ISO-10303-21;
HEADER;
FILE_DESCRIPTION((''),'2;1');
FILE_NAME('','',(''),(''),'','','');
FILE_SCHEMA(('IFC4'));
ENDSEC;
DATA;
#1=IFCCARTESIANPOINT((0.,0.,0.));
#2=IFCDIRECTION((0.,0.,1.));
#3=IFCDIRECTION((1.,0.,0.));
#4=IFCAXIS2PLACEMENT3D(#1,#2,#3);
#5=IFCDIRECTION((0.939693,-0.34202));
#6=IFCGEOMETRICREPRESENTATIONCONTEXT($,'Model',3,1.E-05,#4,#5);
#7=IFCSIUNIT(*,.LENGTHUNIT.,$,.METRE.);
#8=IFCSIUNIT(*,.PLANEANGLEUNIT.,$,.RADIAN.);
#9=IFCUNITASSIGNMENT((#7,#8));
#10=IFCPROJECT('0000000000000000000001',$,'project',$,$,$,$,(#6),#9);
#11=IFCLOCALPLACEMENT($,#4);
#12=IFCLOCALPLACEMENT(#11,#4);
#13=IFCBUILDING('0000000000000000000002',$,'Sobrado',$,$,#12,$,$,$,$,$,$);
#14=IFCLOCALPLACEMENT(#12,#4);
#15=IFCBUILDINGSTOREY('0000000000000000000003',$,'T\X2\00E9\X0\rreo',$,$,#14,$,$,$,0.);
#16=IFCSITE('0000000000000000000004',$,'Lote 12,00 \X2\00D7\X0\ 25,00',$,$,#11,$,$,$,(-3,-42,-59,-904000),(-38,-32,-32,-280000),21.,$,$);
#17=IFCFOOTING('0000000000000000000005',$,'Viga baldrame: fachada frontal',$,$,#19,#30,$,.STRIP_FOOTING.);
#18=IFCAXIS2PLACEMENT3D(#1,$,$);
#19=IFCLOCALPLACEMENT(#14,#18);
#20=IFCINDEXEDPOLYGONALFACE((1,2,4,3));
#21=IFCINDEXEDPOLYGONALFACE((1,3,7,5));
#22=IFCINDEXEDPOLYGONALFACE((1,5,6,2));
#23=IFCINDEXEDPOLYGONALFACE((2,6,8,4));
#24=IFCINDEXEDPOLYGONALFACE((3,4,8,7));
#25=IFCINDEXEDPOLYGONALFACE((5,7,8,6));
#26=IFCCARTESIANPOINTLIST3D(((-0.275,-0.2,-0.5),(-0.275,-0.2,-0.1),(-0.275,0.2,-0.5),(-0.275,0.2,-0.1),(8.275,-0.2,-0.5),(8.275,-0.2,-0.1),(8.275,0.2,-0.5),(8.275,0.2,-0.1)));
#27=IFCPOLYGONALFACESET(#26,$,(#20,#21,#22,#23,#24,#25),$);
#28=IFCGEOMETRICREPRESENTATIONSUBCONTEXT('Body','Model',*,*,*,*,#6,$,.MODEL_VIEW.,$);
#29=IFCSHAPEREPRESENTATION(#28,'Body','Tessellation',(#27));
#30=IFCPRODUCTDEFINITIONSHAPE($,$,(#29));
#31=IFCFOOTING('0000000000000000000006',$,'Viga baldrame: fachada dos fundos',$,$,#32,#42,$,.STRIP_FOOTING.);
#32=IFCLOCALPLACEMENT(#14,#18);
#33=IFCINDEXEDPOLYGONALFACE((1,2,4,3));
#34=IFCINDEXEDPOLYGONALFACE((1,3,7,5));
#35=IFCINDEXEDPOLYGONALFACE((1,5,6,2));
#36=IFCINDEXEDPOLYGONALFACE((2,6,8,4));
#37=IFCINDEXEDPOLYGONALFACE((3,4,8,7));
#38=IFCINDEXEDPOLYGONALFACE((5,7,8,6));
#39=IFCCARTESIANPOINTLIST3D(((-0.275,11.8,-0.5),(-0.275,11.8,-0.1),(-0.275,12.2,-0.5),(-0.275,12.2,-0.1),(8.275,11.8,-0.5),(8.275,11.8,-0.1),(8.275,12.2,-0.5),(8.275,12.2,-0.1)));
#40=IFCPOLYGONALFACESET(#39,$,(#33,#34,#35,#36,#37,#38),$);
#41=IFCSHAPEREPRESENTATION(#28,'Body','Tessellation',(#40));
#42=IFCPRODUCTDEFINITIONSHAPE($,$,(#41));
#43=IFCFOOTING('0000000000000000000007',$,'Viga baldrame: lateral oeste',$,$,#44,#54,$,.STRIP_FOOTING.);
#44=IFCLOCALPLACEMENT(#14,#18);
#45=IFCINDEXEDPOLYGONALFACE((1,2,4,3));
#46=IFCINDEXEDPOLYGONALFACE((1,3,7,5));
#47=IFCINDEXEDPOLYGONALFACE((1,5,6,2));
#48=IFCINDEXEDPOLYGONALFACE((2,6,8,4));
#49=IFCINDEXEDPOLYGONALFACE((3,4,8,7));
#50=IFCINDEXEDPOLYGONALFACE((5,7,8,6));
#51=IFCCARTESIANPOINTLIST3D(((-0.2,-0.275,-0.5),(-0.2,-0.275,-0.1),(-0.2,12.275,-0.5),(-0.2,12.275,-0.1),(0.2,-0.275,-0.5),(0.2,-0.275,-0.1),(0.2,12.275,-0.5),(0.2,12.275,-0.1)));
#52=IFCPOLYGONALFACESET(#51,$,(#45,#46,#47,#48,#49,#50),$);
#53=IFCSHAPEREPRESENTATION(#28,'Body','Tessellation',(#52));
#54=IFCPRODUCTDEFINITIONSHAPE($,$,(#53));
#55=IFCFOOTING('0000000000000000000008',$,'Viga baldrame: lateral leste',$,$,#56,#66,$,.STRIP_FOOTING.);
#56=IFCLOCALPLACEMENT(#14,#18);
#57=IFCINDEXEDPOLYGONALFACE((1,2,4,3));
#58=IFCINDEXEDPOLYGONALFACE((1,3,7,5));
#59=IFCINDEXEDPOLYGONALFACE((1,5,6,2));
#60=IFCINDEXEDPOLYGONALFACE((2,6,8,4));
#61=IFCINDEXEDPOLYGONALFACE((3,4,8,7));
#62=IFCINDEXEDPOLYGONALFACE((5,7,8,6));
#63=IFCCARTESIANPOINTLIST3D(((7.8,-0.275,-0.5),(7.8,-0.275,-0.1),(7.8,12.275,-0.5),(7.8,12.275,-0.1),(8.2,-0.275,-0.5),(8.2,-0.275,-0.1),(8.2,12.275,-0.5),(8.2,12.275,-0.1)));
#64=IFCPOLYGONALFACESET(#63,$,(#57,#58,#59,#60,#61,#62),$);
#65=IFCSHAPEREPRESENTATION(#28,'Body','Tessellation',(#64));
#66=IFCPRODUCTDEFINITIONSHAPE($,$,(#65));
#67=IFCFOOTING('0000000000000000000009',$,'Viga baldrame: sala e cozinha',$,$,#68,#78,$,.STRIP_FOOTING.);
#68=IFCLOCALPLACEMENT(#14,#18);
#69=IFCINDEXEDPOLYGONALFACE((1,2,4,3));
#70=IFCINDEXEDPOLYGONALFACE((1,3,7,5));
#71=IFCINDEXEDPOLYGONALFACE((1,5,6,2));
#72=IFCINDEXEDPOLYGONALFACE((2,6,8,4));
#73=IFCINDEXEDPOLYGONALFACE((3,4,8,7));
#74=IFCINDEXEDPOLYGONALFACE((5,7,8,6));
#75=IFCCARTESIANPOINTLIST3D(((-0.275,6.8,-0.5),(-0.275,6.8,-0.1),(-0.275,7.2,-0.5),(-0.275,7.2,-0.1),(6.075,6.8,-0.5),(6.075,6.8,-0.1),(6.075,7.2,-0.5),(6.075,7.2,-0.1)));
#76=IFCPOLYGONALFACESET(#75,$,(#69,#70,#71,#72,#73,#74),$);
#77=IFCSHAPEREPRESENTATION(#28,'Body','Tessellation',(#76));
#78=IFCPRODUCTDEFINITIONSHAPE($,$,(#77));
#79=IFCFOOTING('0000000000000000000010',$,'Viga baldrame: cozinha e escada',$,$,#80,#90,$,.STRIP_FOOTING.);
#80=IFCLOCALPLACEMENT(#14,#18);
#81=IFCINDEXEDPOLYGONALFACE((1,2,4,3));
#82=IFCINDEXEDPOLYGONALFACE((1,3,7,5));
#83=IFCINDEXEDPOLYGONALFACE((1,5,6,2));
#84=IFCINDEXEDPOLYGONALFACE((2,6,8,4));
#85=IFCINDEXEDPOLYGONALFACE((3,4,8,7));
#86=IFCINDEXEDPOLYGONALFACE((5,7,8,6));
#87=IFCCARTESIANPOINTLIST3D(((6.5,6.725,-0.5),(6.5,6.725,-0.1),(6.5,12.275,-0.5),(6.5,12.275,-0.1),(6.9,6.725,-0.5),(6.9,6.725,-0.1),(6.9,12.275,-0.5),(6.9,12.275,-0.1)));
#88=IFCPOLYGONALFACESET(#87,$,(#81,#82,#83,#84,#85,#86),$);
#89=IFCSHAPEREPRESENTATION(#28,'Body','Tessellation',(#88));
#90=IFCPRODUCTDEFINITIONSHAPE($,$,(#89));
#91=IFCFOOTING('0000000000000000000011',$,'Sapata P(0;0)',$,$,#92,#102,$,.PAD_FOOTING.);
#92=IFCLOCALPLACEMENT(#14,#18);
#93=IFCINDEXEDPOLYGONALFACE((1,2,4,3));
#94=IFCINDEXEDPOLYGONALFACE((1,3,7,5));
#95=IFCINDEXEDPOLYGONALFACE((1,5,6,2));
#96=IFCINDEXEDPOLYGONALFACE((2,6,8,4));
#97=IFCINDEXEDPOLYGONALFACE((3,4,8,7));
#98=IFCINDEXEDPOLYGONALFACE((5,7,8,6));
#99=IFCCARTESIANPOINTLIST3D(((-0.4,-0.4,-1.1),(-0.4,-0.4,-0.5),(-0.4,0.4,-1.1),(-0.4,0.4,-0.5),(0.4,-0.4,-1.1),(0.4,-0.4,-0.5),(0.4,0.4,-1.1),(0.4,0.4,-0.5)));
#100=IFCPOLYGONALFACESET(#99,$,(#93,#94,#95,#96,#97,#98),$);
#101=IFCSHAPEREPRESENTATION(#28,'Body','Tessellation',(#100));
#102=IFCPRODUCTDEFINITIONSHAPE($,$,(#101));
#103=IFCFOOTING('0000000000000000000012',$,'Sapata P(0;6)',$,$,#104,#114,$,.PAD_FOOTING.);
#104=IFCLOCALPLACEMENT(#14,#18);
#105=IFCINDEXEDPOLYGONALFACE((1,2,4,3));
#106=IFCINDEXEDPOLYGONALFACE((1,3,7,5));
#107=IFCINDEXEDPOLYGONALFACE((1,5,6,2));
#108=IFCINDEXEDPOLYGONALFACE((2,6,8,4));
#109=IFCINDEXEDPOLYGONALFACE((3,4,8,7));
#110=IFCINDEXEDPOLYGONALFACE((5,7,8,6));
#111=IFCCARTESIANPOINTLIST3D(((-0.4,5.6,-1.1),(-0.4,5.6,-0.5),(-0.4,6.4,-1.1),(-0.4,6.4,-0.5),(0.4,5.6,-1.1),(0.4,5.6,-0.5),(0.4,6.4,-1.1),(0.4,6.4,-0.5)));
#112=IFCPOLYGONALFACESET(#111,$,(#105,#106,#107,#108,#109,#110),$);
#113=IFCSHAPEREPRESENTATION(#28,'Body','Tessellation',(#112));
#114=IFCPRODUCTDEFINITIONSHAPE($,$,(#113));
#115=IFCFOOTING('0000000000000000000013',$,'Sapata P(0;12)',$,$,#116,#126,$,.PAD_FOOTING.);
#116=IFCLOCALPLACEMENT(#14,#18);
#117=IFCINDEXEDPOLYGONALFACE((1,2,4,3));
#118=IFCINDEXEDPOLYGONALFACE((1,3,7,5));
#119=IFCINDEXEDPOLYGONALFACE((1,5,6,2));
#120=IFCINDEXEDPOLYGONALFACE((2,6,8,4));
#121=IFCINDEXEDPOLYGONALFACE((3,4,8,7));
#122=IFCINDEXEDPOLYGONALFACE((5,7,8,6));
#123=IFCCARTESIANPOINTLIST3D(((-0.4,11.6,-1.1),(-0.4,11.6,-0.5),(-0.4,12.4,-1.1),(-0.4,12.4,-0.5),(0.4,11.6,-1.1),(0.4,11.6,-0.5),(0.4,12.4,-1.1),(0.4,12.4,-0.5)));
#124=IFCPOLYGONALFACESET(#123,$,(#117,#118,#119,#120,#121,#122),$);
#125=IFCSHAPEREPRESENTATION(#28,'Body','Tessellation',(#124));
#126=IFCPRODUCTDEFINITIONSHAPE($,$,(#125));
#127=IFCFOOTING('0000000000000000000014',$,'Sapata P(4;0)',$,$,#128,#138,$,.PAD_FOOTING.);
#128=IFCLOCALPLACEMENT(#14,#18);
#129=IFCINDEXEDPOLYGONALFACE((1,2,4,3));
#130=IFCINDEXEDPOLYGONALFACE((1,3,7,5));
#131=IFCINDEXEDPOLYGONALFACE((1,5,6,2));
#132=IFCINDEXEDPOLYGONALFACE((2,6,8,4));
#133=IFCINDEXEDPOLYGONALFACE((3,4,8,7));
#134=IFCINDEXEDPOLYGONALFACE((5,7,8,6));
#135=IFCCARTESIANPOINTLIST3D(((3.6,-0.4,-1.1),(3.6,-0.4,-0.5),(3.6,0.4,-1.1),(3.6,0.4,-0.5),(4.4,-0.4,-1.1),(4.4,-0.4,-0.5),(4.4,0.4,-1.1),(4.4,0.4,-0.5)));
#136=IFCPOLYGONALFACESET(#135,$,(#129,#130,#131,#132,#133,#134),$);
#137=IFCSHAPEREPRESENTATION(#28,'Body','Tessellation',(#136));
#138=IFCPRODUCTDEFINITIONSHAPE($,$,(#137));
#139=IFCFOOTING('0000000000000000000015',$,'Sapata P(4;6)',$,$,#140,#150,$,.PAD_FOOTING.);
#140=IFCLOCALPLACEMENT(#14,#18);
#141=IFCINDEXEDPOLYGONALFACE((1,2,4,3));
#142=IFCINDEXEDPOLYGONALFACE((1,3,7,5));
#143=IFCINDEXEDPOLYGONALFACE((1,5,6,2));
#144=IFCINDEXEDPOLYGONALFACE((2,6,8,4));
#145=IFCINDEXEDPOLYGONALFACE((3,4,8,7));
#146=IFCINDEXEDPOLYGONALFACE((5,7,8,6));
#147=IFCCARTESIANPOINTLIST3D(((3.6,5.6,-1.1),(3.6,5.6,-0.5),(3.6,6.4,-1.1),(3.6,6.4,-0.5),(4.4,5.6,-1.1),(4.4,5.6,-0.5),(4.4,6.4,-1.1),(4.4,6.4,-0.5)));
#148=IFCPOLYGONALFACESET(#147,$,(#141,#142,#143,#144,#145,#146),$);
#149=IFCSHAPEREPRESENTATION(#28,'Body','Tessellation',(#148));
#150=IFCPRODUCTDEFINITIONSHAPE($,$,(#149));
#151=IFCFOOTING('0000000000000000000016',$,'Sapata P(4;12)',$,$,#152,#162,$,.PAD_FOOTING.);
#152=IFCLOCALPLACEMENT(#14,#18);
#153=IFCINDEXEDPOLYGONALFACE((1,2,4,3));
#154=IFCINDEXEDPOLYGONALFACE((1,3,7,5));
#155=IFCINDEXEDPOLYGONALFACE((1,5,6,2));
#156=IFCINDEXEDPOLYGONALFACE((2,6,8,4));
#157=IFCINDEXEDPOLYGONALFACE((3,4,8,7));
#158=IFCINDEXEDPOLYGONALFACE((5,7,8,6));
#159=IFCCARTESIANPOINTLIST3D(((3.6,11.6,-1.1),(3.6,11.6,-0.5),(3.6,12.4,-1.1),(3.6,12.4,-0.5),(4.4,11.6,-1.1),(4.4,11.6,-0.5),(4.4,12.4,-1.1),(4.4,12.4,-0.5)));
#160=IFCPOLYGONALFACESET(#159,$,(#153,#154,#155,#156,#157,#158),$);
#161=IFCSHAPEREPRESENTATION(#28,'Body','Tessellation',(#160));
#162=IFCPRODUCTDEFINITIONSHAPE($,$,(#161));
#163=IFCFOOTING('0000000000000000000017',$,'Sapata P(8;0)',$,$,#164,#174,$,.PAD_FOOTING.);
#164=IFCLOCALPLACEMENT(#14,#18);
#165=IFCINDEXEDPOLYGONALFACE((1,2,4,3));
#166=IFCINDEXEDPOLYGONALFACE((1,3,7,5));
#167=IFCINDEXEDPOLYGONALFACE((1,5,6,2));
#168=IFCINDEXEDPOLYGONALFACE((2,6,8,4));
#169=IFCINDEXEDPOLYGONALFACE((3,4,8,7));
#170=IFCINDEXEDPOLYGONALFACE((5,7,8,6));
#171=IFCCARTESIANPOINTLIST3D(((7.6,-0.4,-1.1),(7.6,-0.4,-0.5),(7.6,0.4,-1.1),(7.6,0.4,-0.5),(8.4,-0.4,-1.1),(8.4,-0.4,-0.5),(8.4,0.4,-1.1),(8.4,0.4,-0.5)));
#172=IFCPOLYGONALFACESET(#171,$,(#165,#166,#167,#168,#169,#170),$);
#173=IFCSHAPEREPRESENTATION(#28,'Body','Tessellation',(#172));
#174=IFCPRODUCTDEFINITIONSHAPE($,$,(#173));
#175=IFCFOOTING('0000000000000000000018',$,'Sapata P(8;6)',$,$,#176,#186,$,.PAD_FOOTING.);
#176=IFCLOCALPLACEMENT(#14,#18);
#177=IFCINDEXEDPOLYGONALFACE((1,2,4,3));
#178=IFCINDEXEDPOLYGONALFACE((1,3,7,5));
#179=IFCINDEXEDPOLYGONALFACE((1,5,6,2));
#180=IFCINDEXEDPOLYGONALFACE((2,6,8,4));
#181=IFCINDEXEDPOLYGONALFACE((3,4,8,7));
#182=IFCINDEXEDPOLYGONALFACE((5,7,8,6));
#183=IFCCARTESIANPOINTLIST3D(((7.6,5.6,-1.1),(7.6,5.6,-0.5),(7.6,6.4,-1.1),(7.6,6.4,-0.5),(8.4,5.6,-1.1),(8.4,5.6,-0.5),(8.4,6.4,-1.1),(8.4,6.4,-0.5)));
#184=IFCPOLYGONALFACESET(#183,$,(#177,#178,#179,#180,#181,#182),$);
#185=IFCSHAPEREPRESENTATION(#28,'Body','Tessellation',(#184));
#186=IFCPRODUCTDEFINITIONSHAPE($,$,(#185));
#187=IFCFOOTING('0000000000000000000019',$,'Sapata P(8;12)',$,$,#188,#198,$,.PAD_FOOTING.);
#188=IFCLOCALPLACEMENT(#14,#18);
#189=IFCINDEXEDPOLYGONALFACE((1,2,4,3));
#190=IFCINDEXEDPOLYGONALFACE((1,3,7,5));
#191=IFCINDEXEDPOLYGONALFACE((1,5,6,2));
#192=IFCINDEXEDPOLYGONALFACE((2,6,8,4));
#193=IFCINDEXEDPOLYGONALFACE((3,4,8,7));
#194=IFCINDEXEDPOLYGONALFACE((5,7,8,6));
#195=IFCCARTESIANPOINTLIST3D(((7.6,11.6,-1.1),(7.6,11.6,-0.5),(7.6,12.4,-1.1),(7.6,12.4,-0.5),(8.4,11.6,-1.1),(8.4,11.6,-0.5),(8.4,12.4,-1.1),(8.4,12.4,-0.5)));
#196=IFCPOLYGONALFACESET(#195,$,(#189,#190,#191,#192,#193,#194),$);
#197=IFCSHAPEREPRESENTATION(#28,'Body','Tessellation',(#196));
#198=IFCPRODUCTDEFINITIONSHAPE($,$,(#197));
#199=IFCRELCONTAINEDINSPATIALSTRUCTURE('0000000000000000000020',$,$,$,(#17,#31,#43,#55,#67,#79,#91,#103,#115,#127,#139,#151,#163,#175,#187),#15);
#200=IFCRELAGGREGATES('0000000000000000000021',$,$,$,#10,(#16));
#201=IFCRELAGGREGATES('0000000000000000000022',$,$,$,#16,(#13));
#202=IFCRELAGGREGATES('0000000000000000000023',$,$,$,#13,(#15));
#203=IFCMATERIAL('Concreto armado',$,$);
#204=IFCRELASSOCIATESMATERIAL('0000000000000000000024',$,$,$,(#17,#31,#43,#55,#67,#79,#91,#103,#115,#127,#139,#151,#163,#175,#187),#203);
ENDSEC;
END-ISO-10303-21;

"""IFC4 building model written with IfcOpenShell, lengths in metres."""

from ifc_helpers import new_model, si_unit, direction, frame, origin_with_axes, place, context, subcontext, project, spatial, line, indexed_curve, outline, extrude, material, element, save


model = new_model("IFC4")

# Units and contexts
model_context = context("Model", 3, precision=1e-05, world=origin_with_axes(), true_north=direction((0.939693, -0.34202)))
body_context = subcontext(model_context, "Body", "Model", "MODEL_VIEW")
ifc_project = project(units=[si_unit("LENGTHUNIT", "METRE"), si_unit("PLANEANGLEUNIT", "RADIAN")], contexts=[model_context])

# Site, building, storey
site_placement = place(None, origin_with_axes())
site = spatial("IfcSite", under=ifc_project, at=site_placement, Name="Lote 12,00 × 25,00", RefLatitude=(-3, -42, -59, -904000), RefLongitude=(-38, -32, -32, -280000), RefElevation=21.0)
building_placement = place(site_placement, origin_with_axes())
building = spatial("IfcBuilding", under=site, at=building_placement, Name="Sobrado")
storey_placement = place(building_placement, origin_with_axes())
storey = spatial("IfcBuildingStorey", under=building, at=storey_placement, Name="Térreo", Elevation=0.0)

# Footings
ifc_material = material(Name="Concreto armado")
footing_1_placement = place(storey_placement, origin_with_axes())
element("IfcFooting", 1, at=footing_1_placement, inside=storey, material=ifc_material, Name="Viga baldrame: fachada frontal", PredefinedType="STRIP_FOOTING", context=body_context, shape_type="SweptSolid", body=[
    extrude(outline(indexed_curve([(-0.275, -0.2), (8.275, -0.2), (8.275, 0.2), (-0.275, 0.2)], segments=[line(1, 2, 3, 4, 1)])), frame((0.0, 0.0, -0.5), z_axis=(0.0, 0.0, 1.0), x_axis=(1.0, 0.0, 0.0)), (0.0, 0.0, 1.0), 0.4),
])
footing_2_placement = place(storey_placement, origin_with_axes())
element("IfcFooting", 2, at=footing_2_placement, inside=storey, material=ifc_material, Name="Viga baldrame: fachada dos fundos", PredefinedType="STRIP_FOOTING", context=body_context, shape_type="SweptSolid", body=[
    extrude(outline(indexed_curve([(-0.275, 11.8), (8.275, 11.8), (8.275, 12.2), (-0.275, 12.2)], segments=[line(1, 2, 3, 4, 1)])), frame((0.0, 0.0, -0.5), z_axis=(0.0, 0.0, 1.0), x_axis=(1.0, 0.0, 0.0)), (0.0, 0.0, 1.0), 0.4),
])
footing_3_placement = place(storey_placement, origin_with_axes())
element("IfcFooting", 3, at=footing_3_placement, inside=storey, material=ifc_material, Name="Viga baldrame: lateral oeste", PredefinedType="STRIP_FOOTING", context=body_context, shape_type="SweptSolid", body=[
    extrude(outline(indexed_curve([(-0.2, -0.275), (0.2, -0.275), (0.2, 12.275), (-0.2, 12.275)], segments=[line(1, 2, 3, 4, 1)])), frame((0.0, 0.0, -0.5), z_axis=(0.0, 0.0, 1.0), x_axis=(1.0, 0.0, 0.0)), (0.0, 0.0, 1.0), 0.4),
])
footing_4_placement = place(storey_placement, origin_with_axes())
element("IfcFooting", 4, at=footing_4_placement, inside=storey, material=ifc_material, Name="Viga baldrame: lateral leste", PredefinedType="STRIP_FOOTING", context=body_context, shape_type="SweptSolid", body=[
    extrude(outline(indexed_curve([(7.8, -0.275), (8.2, -0.275), (8.2, 12.275), (7.8, 12.275)], segments=[line(1, 2, 3, 4, 1)])), frame((0.0, 0.0, -0.5), z_axis=(0.0, 0.0, 1.0), x_axis=(1.0, 0.0, 0.0)), (0.0, 0.0, 1.0), 0.4),
])
footing_5_placement = place(storey_placement, origin_with_axes())
element("IfcFooting", 5, at=footing_5_placement, inside=storey, material=ifc_material, Name="Viga baldrame: sala e cozinha", PredefinedType="STRIP_FOOTING", context=body_context, shape_type="SweptSolid", body=[
    extrude(outline(indexed_curve([(-0.275, 6.8), (6.075, 6.8), (6.075, 7.2), (-0.275, 7.2)], segments=[line(1, 2, 3, 4, 1)])), frame((0.0, 0.0, -0.5), z_axis=(0.0, 0.0, 1.0), x_axis=(1.0, 0.0, 0.0)), (0.0, 0.0, 1.0), 0.4),
])
footing_6_placement = place(storey_placement, origin_with_axes())
element("IfcFooting", 6, at=footing_6_placement, inside=storey, material=ifc_material, Name="Viga baldrame: cozinha e escada", PredefinedType="STRIP_FOOTING", context=body_context, shape_type="SweptSolid", body=[
    extrude(outline(indexed_curve([(6.5, 6.725), (6.9, 6.725), (6.9, 12.275), (6.5, 12.275)], segments=[line(1, 2, 3, 4, 1)])), frame((0.0, 0.0, -0.5), z_axis=(0.0, 0.0, 1.0), x_axis=(1.0, 0.0, 0.0)), (0.0, 0.0, 1.0), 0.4),
])
footing_7_placement = place(storey_placement, origin_with_axes())
element("IfcFooting", 7, at=footing_7_placement, inside=storey, material=ifc_material, Name="Sapata P(0;0)", PredefinedType="PAD_FOOTING", context=body_context, shape_type="SweptSolid", body=[
    extrude(outline(indexed_curve([(-0.4, -0.4), (0.4, -0.4), (0.4, 0.4), (-0.4, 0.4)], segments=[line(1, 2, 3, 4, 1)])), frame((0.0, 0.0, -1.1), z_axis=(0.0, 0.0, 1.0), x_axis=(1.0, 0.0, 0.0)), (0.0, 0.0, 1.0), 0.6),
])
footing_8_placement = place(storey_placement, origin_with_axes())
element("IfcFooting", 8, at=footing_8_placement, inside=storey, material=ifc_material, Name="Sapata P(0;6)", PredefinedType="PAD_FOOTING", context=body_context, shape_type="SweptSolid", body=[
    extrude(outline(indexed_curve([(-0.4, 5.6), (0.4, 5.6), (0.4, 6.4), (-0.4, 6.4)], segments=[line(1, 2, 3, 4, 1)])), frame((0.0, 0.0, -1.1), z_axis=(0.0, 0.0, 1.0), x_axis=(1.0, 0.0, 0.0)), (0.0, 0.0, 1.0), 0.6),
])
footing_9_placement = place(storey_placement, origin_with_axes())
element("IfcFooting", 9, at=footing_9_placement, inside=storey, material=ifc_material, Name="Sapata P(0;12)", PredefinedType="PAD_FOOTING", context=body_context, shape_type="SweptSolid", body=[
    extrude(outline(indexed_curve([(-0.4, 11.6), (0.4, 11.6), (0.4, 12.4), (-0.4, 12.4)], segments=[line(1, 2, 3, 4, 1)])), frame((0.0, 0.0, -1.1), z_axis=(0.0, 0.0, 1.0), x_axis=(1.0, 0.0, 0.0)), (0.0, 0.0, 1.0), 0.6),
])
footing_10_placement = place(storey_placement, origin_with_axes())
element("IfcFooting", 10, at=footing_10_placement, inside=storey, material=ifc_material, Name="Sapata P(4;0)", PredefinedType="PAD_FOOTING", context=body_context, shape_type="SweptSolid", body=[
    extrude(outline(indexed_curve([(3.6, -0.4), (4.4, -0.4), (4.4, 0.4), (3.6, 0.4)], segments=[line(1, 2, 3, 4, 1)])), frame((0.0, 0.0, -1.1), z_axis=(0.0, 0.0, 1.0), x_axis=(1.0, 0.0, 0.0)), (0.0, 0.0, 1.0), 0.6),
])
footing_11_placement = place(storey_placement, origin_with_axes())
element("IfcFooting", 11, at=footing_11_placement, inside=storey, material=ifc_material, Name="Sapata P(4;6)", PredefinedType="PAD_FOOTING", context=body_context, shape_type="SweptSolid", body=[
    extrude(outline(indexed_curve([(3.6, 5.6), (4.4, 5.6), (4.4, 6.4), (3.6, 6.4)], segments=[line(1, 2, 3, 4, 1)])), frame((0.0, 0.0, -1.1), z_axis=(0.0, 0.0, 1.0), x_axis=(1.0, 0.0, 0.0)), (0.0, 0.0, 1.0), 0.6),
])
footing_12_placement = place(storey_placement, origin_with_axes())
element("IfcFooting", 12, at=footing_12_placement, inside=storey, material=ifc_material, Name="Sapata P(4;12)", PredefinedType="PAD_FOOTING", context=body_context, shape_type="SweptSolid", body=[
    extrude(outline(indexed_curve([(3.6, 11.6), (4.4, 11.6), (4.4, 12.4), (3.6, 12.4)], segments=[line(1, 2, 3, 4, 1)])), frame((0.0, 0.0, -1.1), z_axis=(0.0, 0.0, 1.0), x_axis=(1.0, 0.0, 0.0)), (0.0, 0.0, 1.0), 0.6),
])
footing_13_placement = place(storey_placement, origin_with_axes())
element("IfcFooting", 13, at=footing_13_placement, inside=storey, material=ifc_material, Name="Sapata P(8;0)", PredefinedType="PAD_FOOTING", context=body_context, shape_type="SweptSolid", body=[
    extrude(outline(indexed_curve([(7.6, -0.4), (8.4, -0.4), (8.4, 0.4), (7.6, 0.4)], segments=[line(1, 2, 3, 4, 1)])), frame((0.0, 0.0, -1.1), z_axis=(0.0, 0.0, 1.0), x_axis=(1.0, 0.0, 0.0)), (0.0, 0.0, 1.0), 0.6),
])
footing_14_placement = place(storey_placement, origin_with_axes())
element("IfcFooting", 14, at=footing_14_placement, inside=storey, material=ifc_material, Name="Sapata P(8;6)", PredefinedType="PAD_FOOTING", context=body_context, shape_type="SweptSolid", body=[
    extrude(outline(indexed_curve([(7.6, 5.6), (8.4, 5.6), (8.4, 6.4), (7.6, 6.4)], segments=[line(1, 2, 3, 4, 1)])), frame((0.0, 0.0, -1.1), z_axis=(0.0, 0.0, 1.0), x_axis=(1.0, 0.0, 0.0)), (0.0, 0.0, 1.0), 0.6),
])
footing_15_placement = place(storey_placement, origin_with_axes())
element("IfcFooting", 15, at=footing_15_placement, inside=storey, material=ifc_material, Name="Sapata P(8;12)", PredefinedType="PAD_FOOTING", context=body_context, shape_type="SweptSolid", body=[
    extrude(outline(indexed_curve([(7.6, 11.6), (8.4, 11.6), (8.4, 12.4), (7.6, 12.4)], segments=[line(1, 2, 3, 4, 1)])), frame((0.0, 0.0, -1.1), z_axis=(0.0, 0.0, 1.0), x_axis=(1.0, 0.0, 0.0)), (0.0, 0.0, 1.0), 0.6),
])

save(model, "model.ifc")
